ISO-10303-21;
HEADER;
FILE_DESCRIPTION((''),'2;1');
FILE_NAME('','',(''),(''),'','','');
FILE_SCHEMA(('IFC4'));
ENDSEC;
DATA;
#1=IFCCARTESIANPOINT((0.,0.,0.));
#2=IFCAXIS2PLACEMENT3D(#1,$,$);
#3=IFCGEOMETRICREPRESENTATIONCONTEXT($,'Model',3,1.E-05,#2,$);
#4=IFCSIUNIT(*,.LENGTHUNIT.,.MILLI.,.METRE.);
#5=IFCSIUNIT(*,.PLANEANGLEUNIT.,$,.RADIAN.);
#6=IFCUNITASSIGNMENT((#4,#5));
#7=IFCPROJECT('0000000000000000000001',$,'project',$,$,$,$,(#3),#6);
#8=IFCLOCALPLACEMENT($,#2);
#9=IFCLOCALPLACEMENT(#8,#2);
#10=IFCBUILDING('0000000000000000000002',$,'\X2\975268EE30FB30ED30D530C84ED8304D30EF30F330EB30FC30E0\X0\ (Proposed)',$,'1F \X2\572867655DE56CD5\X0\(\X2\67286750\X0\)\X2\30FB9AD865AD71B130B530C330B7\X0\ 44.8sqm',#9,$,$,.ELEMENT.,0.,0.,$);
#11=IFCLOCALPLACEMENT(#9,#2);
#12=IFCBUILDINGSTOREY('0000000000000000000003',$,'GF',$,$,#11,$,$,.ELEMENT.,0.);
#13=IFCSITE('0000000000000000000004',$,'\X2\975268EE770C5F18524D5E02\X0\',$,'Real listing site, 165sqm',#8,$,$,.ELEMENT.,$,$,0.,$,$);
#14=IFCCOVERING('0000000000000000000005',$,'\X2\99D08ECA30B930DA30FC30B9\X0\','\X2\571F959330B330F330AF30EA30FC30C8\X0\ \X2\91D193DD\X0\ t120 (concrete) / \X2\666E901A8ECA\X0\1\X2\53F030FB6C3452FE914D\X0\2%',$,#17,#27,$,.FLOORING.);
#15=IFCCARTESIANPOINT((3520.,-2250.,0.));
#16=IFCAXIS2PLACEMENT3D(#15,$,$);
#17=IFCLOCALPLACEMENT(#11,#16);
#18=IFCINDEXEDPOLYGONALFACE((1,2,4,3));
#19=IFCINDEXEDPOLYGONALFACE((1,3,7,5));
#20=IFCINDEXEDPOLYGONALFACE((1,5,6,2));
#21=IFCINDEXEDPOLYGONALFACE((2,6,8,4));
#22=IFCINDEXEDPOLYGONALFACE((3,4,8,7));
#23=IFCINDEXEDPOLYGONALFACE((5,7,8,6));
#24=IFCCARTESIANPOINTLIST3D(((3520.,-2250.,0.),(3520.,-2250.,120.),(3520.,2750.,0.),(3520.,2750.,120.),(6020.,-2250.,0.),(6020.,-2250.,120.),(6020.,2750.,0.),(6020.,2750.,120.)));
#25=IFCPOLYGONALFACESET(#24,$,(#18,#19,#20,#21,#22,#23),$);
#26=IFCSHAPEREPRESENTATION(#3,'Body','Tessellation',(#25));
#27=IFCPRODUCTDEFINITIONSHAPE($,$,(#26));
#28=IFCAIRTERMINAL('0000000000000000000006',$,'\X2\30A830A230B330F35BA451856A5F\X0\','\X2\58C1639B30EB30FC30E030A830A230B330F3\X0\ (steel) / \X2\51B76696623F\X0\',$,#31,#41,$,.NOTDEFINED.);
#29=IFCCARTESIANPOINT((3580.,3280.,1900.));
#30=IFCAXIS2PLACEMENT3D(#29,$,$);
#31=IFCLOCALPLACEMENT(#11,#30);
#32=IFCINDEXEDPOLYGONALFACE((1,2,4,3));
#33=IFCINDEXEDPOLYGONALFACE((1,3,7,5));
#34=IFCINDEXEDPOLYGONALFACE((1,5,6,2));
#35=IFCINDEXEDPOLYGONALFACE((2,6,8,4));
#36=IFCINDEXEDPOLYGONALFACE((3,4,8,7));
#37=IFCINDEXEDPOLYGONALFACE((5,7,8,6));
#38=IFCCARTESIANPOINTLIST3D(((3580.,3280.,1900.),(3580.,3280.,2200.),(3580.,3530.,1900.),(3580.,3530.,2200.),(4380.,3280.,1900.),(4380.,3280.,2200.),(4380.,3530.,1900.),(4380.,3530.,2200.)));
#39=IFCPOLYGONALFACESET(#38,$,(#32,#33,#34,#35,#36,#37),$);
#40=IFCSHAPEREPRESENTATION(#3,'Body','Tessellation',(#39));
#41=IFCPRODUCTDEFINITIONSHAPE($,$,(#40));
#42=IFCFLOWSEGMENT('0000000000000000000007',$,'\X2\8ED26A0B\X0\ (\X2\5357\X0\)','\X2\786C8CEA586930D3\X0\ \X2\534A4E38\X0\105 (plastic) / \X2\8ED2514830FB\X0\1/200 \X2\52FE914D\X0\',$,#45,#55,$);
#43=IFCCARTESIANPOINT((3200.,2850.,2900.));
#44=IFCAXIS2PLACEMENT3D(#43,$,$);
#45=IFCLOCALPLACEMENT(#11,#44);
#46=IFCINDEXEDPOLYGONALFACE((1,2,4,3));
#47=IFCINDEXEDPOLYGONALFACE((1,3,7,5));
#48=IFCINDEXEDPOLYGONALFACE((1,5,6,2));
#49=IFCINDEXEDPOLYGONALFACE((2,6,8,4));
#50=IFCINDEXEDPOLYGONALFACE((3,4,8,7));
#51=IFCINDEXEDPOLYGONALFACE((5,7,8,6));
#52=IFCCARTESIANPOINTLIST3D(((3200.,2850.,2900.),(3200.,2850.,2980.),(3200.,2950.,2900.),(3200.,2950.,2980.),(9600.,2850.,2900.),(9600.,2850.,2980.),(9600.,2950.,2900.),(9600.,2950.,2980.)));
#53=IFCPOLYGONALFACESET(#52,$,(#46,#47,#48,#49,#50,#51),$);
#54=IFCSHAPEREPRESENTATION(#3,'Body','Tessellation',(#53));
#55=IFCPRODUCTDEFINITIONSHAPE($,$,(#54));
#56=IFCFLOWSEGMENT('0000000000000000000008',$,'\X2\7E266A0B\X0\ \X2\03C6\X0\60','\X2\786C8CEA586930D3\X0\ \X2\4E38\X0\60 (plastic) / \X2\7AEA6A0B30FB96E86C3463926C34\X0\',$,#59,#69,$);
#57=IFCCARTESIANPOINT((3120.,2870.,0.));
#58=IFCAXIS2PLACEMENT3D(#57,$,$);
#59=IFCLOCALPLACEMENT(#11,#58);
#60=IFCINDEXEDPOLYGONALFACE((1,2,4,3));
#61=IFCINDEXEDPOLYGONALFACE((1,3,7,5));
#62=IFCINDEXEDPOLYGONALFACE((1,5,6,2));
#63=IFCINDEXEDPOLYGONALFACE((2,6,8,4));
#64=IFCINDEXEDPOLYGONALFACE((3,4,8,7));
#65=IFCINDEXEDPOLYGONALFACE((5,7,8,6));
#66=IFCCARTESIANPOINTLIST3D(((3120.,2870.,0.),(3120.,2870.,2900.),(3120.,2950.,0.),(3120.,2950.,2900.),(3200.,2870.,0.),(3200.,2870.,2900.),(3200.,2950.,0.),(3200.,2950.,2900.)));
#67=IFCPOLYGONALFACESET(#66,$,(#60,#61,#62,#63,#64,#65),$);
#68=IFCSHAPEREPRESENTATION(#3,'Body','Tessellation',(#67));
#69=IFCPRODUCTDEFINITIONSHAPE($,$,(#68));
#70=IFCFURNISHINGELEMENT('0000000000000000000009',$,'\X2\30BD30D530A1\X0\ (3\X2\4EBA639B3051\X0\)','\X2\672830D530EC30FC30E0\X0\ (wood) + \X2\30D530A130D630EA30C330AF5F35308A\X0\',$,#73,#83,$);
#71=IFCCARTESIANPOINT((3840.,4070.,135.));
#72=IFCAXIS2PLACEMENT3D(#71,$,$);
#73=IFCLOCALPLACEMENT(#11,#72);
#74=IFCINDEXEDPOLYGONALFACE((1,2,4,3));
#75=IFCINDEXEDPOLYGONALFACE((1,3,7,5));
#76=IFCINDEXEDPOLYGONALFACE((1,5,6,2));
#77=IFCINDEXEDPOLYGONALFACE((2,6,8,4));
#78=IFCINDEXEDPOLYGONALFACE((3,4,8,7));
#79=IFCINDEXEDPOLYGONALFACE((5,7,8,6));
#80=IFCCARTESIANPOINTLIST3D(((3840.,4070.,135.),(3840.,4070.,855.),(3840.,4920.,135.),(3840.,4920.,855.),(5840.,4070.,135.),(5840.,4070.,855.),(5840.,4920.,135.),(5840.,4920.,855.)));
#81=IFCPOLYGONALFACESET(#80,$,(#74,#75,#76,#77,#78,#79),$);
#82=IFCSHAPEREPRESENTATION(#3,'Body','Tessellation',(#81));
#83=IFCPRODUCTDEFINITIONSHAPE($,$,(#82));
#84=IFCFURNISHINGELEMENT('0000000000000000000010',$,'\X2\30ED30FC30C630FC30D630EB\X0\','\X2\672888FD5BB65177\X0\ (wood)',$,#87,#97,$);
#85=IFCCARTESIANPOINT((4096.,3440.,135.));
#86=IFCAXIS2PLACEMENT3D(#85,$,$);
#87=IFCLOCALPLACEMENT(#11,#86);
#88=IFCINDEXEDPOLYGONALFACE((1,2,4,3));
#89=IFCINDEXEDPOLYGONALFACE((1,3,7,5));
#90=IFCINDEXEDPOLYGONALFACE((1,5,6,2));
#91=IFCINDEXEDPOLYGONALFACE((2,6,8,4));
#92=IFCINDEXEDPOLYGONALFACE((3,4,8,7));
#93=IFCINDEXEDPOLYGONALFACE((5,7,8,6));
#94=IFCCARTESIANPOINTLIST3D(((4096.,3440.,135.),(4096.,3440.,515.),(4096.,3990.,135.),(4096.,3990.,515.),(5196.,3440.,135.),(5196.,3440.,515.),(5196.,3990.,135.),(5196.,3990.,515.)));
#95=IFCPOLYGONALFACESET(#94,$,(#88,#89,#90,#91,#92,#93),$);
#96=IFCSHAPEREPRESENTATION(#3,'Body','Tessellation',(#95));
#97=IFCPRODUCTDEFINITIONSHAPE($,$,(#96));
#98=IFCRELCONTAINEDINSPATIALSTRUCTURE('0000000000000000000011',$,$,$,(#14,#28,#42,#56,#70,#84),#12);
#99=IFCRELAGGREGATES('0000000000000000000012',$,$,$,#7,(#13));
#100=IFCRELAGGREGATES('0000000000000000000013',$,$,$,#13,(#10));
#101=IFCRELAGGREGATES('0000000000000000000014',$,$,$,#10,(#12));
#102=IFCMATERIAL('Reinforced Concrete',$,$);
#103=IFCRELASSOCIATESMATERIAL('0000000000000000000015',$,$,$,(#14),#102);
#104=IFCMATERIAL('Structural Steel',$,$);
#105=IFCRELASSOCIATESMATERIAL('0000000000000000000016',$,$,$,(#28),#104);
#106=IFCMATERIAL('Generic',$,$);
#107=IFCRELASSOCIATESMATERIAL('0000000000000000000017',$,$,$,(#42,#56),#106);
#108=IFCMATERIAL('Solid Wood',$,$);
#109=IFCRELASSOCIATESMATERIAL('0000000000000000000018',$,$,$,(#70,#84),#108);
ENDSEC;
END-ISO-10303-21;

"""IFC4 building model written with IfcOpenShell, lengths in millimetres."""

from ifc_helpers import new_model, si_unit, frame, frame_2d, origin, place, context, project, spatial, rectangle, extrude, material, element, save


model = new_model("IFC4")

# Units and contexts
model_context = context("Model", 3, precision=1e-05, world=origin())
ifc_project = project(units=[si_unit("LENGTHUNIT", "METRE", prefix="MILLI"), si_unit("PLANEANGLEUNIT", "RADIAN")], contexts=[model_context])

# Site, building, storey
site_placement = place(None, origin())
site = spatial("IfcSite", under=ifc_project, at=site_placement, Name="青森県弘前市", ObjectType="Real listing site, 165sqm", CompositionType="ELEMENT", RefElevation=0.0)
building_placement = place(site_placement, origin())
building = spatial("IfcBuilding", under=site, at=building_placement, Name="青森・ロフト付きワンルーム (Proposed)", ObjectType="1F 在来工法(木材)・高断熱サッシ 44.8sqm", CompositionType="ELEMENT", ElevationOfRefHeight=0.0, ElevationOfTerrain=0.0)
storey_placement = place(building_placement, origin())
storey = spatial("IfcBuildingStorey", under=building, at=storey_placement, Name="GF", CompositionType="ELEMENT", Elevation=0.0)

# Shared definitions
ifc_material_1 = material(Name="Solid Wood")

# Shared definitions
ifc_material_2 = material(Name="Reinforced Concrete")

# Shared definitions
ifc_material_3 = material(Name="Structural Steel")

# Covering
ifc_material_4 = material(Name="Generic")
covering_1_placement = place(storey_placement, frame((3520.0, -2250.0, 0.0)))
element("IfcCovering", 1, at=covering_1_placement, inside=storey, material=ifc_material_2, Name="駐車スペース", Description="土間コンクリート 金鏝 t120 (concrete) / 普通車1台・水勾配2%", PredefinedType="FLOORING", context=model_context, shape_type="SweptSolid", body=[
    extrude(rectangle(XDim=2500.0, YDim=5000.0, at=frame_2d((1250.0, 2500.0))), frame((3520.0, -2250.0, 0.0)), (0.0, 0.0, 1.0), 120.0),
])

# Air terminal
air_terminal_placement = place(storey_placement, frame((3580.0, 3280.0, 1900.0)))
element("IfcAirTerminal", 2, at=air_terminal_placement, inside=storey, material=ifc_material_3, Name="エアコン室内機", Description="壁掛ルームエアコン (steel) / 冷暖房", PredefinedType="NOTDEFINED", context=model_context, shape_type="SweptSolid", body=[
    extrude(rectangle(XDim=800.0, YDim=250.0, at=frame_2d((400.0, 125.0))), frame((3580.0, 3280.0, 1900.0)), (0.0, 0.0, 1.0), 300.0),
])

# Flow segments
flow_segment_1_placement = place(storey_placement, frame((3200.0, 2850.0, 2900.0)))
element("IfcFlowSegment", 3, at=flow_segment_1_placement, inside=storey, material=ifc_material_4, Name="軒樋 (南)", Description="硬質塩ビ 半丸105 (plastic) / 軒先・1/200 勾配", context=model_context, shape_type="SweptSolid", body=[
    extrude(rectangle(XDim=6400.0, YDim=100.0, at=frame_2d((3200.0, 50.0))), frame((3200.0, 2850.0, 2900.0)), (0.0, 0.0, 1.0), 80.0),
])
flow_segment_2_placement = place(storey_placement, frame((3120.0, 2870.0, 0.0)))
element("IfcFlowSegment", 4, at=flow_segment_2_placement, inside=storey, material=ifc_material_4, Name="縦樋 φ60", Description="硬質塩ビ 丸60 (plastic) / 竪樋・雨水排水", context=model_context, shape_type="SweptSolid", body=[
    extrude(rectangle(XDim=80.0, YDim=80.0, at=frame_2d((40.0, 40.0))), frame((3120.0, 2870.0, 0.0)), (0.0, 0.0, 1.0), 2900.0),
])

# Furnishing elements
furnishing_1_placement = place(storey_placement, frame((3840.0, 4070.0, 135.0)))
element("IfcFurnishingElement", 5, at=furnishing_1_placement, inside=storey, material=ifc_material_1, Name="ソファ (3人掛け)", Description="木フレーム (wood) + ファブリック張り", context=model_context, shape_type="SweptSolid", body=[
    extrude(rectangle(XDim=2000.0, YDim=850.0, at=frame_2d((1000.0, 425.0))), frame((3840.0, 4070.0, 135.0)), (0.0, 0.0, 1.0), 720.0),
])
furnishing_2_placement = place(storey_placement, frame((4096.0, 3440.0, 135.0)))
element("IfcFurnishingElement", 6, at=furnishing_2_placement, inside=storey, material=ifc_material_1, Name="ローテーブル", Description="木製家具 (wood)", context=model_context, shape_type="SweptSolid", body=[
    extrude(rectangle(XDim=1100.0, YDim=550.0, at=frame_2d((550.0, 275.0))), frame((4096.0, 3440.0, 135.0)), (0.0, 0.0, 1.0), 380.0),
])

save(model, "model.ifc")
